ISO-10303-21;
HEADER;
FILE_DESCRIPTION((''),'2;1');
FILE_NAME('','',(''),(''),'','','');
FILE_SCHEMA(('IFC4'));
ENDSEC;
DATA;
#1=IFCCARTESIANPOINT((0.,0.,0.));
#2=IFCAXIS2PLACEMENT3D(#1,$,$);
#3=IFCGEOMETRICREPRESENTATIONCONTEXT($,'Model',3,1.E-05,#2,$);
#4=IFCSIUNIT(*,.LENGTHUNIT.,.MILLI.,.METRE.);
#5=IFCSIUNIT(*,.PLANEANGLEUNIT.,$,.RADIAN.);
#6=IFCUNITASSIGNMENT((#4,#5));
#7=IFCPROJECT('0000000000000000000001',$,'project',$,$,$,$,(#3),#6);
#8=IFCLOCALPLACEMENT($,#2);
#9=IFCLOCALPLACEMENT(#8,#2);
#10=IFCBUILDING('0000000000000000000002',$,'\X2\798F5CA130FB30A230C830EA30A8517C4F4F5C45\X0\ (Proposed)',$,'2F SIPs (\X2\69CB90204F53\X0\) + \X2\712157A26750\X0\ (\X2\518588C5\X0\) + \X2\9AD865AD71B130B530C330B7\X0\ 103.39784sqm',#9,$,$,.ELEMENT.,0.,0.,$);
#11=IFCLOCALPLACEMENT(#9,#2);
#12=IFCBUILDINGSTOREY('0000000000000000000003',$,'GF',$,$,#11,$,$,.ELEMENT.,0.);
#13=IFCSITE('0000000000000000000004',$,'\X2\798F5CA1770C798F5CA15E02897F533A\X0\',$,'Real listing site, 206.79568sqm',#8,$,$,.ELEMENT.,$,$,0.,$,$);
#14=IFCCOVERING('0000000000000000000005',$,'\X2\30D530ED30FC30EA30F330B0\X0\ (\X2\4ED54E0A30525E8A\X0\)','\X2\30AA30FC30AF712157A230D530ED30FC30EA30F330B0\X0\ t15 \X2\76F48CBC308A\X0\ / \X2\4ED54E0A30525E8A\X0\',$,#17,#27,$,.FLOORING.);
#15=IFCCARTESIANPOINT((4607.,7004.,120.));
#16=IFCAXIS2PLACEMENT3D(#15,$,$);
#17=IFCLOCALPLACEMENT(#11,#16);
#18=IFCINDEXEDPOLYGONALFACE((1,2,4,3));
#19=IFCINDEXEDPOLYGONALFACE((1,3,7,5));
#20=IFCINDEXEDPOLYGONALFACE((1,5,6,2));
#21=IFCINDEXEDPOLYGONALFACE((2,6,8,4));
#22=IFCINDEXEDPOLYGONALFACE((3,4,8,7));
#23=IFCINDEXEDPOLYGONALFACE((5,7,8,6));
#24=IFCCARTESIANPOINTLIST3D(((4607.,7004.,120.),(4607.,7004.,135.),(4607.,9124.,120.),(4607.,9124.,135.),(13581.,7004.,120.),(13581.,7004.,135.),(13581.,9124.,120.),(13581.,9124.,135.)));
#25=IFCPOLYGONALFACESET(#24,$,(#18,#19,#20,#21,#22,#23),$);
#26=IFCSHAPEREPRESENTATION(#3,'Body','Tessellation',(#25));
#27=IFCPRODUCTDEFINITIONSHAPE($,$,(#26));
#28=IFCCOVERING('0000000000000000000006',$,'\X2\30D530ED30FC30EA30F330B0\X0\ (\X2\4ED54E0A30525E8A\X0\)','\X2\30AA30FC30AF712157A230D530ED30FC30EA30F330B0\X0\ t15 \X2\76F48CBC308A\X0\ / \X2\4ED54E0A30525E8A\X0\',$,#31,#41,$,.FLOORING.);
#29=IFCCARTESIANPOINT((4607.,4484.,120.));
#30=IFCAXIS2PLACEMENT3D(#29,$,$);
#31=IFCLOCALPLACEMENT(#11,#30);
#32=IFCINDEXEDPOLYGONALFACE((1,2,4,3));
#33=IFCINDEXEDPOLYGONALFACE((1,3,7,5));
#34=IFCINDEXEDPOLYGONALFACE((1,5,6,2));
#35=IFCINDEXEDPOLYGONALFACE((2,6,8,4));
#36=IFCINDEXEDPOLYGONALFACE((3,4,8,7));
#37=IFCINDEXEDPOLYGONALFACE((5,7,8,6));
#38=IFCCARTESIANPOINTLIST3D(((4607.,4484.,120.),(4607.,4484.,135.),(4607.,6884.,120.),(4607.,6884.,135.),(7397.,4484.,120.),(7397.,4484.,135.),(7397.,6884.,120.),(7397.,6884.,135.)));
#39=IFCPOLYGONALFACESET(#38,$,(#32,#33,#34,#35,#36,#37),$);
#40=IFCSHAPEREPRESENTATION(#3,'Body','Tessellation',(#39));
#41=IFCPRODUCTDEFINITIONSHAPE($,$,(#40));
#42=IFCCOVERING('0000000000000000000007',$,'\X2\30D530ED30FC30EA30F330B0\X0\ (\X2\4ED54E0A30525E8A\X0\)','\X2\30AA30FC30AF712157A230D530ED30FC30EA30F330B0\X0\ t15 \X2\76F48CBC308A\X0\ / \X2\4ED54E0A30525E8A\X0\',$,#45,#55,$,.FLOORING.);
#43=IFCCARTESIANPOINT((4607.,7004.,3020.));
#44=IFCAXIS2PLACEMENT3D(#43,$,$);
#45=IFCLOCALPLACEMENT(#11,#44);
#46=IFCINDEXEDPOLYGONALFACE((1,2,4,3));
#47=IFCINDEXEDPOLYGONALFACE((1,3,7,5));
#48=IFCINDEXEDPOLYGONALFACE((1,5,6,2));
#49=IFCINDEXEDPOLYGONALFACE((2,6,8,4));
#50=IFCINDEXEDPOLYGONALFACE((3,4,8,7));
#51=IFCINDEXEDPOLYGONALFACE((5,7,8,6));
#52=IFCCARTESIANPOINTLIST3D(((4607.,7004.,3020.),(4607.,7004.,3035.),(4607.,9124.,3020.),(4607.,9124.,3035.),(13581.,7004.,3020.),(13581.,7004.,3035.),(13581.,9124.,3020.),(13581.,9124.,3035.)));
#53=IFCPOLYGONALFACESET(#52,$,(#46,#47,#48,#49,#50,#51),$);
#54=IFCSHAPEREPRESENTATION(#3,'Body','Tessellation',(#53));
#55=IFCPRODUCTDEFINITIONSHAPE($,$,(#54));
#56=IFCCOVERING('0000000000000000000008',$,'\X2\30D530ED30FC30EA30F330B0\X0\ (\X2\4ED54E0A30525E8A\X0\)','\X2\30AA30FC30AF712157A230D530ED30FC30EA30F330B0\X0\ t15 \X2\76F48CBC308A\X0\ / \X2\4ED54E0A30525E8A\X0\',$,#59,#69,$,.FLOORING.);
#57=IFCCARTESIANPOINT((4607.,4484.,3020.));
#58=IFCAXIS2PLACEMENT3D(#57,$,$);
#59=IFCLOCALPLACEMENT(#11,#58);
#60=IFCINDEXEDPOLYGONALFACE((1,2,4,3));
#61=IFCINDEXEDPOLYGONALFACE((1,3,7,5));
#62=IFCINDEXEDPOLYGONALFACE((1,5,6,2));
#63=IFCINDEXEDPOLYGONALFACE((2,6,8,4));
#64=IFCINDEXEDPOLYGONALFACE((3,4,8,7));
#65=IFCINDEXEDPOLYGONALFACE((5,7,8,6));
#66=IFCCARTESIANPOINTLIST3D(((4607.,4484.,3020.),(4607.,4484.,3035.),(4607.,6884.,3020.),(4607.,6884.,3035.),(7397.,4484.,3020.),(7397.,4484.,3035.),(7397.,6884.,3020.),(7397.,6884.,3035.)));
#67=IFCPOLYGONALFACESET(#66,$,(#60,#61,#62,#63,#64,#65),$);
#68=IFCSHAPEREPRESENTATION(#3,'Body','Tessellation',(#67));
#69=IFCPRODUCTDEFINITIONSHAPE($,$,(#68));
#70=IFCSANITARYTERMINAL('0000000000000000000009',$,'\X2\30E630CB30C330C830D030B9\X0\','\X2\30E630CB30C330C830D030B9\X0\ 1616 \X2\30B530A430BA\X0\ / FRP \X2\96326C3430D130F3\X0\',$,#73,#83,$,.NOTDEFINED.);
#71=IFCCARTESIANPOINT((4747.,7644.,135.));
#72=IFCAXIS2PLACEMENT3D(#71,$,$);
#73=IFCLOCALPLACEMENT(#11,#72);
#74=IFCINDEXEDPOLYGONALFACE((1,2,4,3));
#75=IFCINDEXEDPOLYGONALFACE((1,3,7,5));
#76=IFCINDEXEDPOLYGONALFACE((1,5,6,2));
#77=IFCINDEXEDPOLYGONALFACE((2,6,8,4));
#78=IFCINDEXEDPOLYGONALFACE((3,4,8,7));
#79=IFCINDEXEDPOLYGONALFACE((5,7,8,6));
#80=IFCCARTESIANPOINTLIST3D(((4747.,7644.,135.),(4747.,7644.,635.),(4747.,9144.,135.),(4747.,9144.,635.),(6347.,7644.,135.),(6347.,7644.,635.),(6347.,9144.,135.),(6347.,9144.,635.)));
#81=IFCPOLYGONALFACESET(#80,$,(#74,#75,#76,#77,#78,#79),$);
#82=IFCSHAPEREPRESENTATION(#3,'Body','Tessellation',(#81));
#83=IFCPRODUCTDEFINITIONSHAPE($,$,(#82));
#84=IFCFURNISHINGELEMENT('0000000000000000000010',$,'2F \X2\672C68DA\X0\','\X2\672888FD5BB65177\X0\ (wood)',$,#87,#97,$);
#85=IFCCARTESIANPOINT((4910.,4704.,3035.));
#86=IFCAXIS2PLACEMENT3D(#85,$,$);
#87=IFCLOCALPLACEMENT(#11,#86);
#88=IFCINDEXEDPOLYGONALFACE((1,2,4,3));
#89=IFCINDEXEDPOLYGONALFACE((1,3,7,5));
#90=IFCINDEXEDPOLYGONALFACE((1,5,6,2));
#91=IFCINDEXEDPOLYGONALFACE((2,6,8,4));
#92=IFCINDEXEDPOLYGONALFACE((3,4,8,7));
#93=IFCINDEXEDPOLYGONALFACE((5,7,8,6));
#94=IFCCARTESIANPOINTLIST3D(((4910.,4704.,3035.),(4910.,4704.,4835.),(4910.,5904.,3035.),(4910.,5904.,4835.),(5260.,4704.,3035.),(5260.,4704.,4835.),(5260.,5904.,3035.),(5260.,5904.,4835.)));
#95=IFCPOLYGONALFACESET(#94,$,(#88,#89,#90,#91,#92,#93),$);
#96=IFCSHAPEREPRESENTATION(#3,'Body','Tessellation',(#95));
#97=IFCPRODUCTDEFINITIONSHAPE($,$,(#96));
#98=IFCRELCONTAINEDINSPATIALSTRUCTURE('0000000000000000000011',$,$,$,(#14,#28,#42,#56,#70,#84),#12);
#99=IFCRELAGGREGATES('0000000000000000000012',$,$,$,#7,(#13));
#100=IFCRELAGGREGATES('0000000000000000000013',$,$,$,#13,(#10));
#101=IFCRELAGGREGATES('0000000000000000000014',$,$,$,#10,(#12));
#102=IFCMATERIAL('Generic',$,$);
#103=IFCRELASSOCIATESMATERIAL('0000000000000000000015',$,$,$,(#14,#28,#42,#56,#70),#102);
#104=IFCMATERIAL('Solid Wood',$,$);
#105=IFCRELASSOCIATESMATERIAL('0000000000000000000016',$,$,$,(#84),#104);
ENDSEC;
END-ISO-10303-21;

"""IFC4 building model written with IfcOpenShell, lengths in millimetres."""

from ifc_helpers import new_model, si_unit, frame, frame_2d, origin, place, context, project, spatial, rectangle, extrude, material, element, save


model = new_model("IFC4")

# Units and contexts
model_context = context("Model", 3, precision=1e-05, world=origin())
ifc_project = project(units=[si_unit("LENGTHUNIT", "METRE", prefix="MILLI"), si_unit("PLANEANGLEUNIT", "RADIAN")], contexts=[model_context])

# Site, building, storey
site_placement = place(None, origin())
site = spatial("IfcSite", under=ifc_project, at=site_placement, Name="福岡県福岡市西区", ObjectType="Real listing site, 206.79568sqm", CompositionType="ELEMENT", RefElevation=0.0)
building_placement = place(site_placement, origin())
building = spatial("IfcBuilding", under=site, at=building_placement, Name="福岡・アトリエ兼住居 (Proposed)", ObjectType="2F SIPs (構造体) + 無垢材 (内装) + 高断熱サッシ 103.39784sqm", CompositionType="ELEMENT", ElevationOfRefHeight=0.0, ElevationOfTerrain=0.0)
storey_placement = place(building_placement, origin())
storey = spatial("IfcBuildingStorey", under=building, at=storey_placement, Name="GF", CompositionType="ELEMENT", Elevation=0.0)

# Shared definitions
ifc_material_1 = material(Name="Solid Wood")

# Coverings
ifc_material_2 = material(Name="Generic")
covering_1_placement = place(storey_placement, frame((4607.0, 7004.0, 120.0)))
element("IfcCovering", 1, at=covering_1_placement, inside=storey, material=ifc_material_2, Name="フローリング (仕上げ床)", Description="オーク無垢フローリング t15 直貼り / 仕上げ床", PredefinedType="FLOORING", context=model_context, shape_type="SweptSolid", body=[
    extrude(rectangle(XDim=8974.0, YDim=2120.0, at=frame_2d((4487.0, 1060.0))), frame((4607.0, 7004.0, 120.0)), (0.0, 0.0, 1.0), 15.0),
])
covering_2_placement = place(storey_placement, frame((4607.0, 4484.0, 120.0)))
element("IfcCovering", 2, at=covering_2_placement, inside=storey, material=ifc_material_2, Name="フローリング (仕上げ床)", Description="オーク無垢フローリング t15 直貼り / 仕上げ床", PredefinedType="FLOORING", context=model_context, shape_type="SweptSolid", body=[
    extrude(rectangle(XDim=2790.0, YDim=2400.0, at=frame_2d((1395.0, 1200.0))), frame((4607.0, 4484.0, 120.0)), (0.0, 0.0, 1.0), 15.0),
])
covering_3_placement = place(storey_placement, frame((4607.0, 7004.0, 3020.0)))
element("IfcCovering", 3, at=covering_3_placement, inside=storey, material=ifc_material_2, Name="フローリング (仕上げ床)", Description="オーク無垢フローリング t15 直貼り / 仕上げ床", PredefinedType="FLOORING", context=model_context, shape_type="SweptSolid", body=[
    extrude(rectangle(XDim=8974.0, YDim=2120.0, at=frame_2d((4487.0, 1060.0))), frame((4607.0, 7004.0, 3020.0)), (0.0, 0.0, 1.0), 15.0),
])
covering_4_placement = place(storey_placement, frame((4607.0, 4484.0, 3020.0)))
element("IfcCovering", 4, at=covering_4_placement, inside=storey, material=ifc_material_2, Name="フローリング (仕上げ床)", Description="オーク無垢フローリング t15 直貼り / 仕上げ床", PredefinedType="FLOORING", context=model_context, shape_type="SweptSolid", body=[
    extrude(rectangle(XDim=2790.0, YDim=2400.0, at=frame_2d((1395.0, 1200.0))), frame((4607.0, 4484.0, 3020.0)), (0.0, 0.0, 1.0), 15.0),
])

# Sanitary terminal
sanitary_terminal_placement = place(storey_placement, frame((4747.0, 7644.0, 135.0)))
element("IfcSanitaryTerminal", 5, at=sanitary_terminal_placement, inside=storey, material=ifc_material_2, Name="ユニットバス", Description="ユニットバス 1616 サイズ / FRP 防水パン", PredefinedType="NOTDEFINED", context=model_context, shape_type="SweptSolid", body=[
    extrude(rectangle(XDim=1600.0, YDim=1500.0, at=frame_2d((800.0, 750.0))), frame((4747.0, 7644.0, 135.0)), (0.0, 0.0, 1.0), 500.0),
])

# Furnishing element
furnishing_placement = place(storey_placement, frame((4910.0, 4704.0, 3035.0)))
element("IfcFurnishingElement", 6, at=furnishing_placement, inside=storey, material=ifc_material_1, Name="2F 本棚", Description="木製家具 (wood)", context=model_context, shape_type="SweptSolid", body=[
    extrude(rectangle(XDim=350.0, YDim=1200.0, at=frame_2d((175.0, 600.0))), frame((4910.0, 4704.0, 3035.0)), (0.0, 0.0, 1.0), 1800.0),
])

save(model, "model.ifc")
